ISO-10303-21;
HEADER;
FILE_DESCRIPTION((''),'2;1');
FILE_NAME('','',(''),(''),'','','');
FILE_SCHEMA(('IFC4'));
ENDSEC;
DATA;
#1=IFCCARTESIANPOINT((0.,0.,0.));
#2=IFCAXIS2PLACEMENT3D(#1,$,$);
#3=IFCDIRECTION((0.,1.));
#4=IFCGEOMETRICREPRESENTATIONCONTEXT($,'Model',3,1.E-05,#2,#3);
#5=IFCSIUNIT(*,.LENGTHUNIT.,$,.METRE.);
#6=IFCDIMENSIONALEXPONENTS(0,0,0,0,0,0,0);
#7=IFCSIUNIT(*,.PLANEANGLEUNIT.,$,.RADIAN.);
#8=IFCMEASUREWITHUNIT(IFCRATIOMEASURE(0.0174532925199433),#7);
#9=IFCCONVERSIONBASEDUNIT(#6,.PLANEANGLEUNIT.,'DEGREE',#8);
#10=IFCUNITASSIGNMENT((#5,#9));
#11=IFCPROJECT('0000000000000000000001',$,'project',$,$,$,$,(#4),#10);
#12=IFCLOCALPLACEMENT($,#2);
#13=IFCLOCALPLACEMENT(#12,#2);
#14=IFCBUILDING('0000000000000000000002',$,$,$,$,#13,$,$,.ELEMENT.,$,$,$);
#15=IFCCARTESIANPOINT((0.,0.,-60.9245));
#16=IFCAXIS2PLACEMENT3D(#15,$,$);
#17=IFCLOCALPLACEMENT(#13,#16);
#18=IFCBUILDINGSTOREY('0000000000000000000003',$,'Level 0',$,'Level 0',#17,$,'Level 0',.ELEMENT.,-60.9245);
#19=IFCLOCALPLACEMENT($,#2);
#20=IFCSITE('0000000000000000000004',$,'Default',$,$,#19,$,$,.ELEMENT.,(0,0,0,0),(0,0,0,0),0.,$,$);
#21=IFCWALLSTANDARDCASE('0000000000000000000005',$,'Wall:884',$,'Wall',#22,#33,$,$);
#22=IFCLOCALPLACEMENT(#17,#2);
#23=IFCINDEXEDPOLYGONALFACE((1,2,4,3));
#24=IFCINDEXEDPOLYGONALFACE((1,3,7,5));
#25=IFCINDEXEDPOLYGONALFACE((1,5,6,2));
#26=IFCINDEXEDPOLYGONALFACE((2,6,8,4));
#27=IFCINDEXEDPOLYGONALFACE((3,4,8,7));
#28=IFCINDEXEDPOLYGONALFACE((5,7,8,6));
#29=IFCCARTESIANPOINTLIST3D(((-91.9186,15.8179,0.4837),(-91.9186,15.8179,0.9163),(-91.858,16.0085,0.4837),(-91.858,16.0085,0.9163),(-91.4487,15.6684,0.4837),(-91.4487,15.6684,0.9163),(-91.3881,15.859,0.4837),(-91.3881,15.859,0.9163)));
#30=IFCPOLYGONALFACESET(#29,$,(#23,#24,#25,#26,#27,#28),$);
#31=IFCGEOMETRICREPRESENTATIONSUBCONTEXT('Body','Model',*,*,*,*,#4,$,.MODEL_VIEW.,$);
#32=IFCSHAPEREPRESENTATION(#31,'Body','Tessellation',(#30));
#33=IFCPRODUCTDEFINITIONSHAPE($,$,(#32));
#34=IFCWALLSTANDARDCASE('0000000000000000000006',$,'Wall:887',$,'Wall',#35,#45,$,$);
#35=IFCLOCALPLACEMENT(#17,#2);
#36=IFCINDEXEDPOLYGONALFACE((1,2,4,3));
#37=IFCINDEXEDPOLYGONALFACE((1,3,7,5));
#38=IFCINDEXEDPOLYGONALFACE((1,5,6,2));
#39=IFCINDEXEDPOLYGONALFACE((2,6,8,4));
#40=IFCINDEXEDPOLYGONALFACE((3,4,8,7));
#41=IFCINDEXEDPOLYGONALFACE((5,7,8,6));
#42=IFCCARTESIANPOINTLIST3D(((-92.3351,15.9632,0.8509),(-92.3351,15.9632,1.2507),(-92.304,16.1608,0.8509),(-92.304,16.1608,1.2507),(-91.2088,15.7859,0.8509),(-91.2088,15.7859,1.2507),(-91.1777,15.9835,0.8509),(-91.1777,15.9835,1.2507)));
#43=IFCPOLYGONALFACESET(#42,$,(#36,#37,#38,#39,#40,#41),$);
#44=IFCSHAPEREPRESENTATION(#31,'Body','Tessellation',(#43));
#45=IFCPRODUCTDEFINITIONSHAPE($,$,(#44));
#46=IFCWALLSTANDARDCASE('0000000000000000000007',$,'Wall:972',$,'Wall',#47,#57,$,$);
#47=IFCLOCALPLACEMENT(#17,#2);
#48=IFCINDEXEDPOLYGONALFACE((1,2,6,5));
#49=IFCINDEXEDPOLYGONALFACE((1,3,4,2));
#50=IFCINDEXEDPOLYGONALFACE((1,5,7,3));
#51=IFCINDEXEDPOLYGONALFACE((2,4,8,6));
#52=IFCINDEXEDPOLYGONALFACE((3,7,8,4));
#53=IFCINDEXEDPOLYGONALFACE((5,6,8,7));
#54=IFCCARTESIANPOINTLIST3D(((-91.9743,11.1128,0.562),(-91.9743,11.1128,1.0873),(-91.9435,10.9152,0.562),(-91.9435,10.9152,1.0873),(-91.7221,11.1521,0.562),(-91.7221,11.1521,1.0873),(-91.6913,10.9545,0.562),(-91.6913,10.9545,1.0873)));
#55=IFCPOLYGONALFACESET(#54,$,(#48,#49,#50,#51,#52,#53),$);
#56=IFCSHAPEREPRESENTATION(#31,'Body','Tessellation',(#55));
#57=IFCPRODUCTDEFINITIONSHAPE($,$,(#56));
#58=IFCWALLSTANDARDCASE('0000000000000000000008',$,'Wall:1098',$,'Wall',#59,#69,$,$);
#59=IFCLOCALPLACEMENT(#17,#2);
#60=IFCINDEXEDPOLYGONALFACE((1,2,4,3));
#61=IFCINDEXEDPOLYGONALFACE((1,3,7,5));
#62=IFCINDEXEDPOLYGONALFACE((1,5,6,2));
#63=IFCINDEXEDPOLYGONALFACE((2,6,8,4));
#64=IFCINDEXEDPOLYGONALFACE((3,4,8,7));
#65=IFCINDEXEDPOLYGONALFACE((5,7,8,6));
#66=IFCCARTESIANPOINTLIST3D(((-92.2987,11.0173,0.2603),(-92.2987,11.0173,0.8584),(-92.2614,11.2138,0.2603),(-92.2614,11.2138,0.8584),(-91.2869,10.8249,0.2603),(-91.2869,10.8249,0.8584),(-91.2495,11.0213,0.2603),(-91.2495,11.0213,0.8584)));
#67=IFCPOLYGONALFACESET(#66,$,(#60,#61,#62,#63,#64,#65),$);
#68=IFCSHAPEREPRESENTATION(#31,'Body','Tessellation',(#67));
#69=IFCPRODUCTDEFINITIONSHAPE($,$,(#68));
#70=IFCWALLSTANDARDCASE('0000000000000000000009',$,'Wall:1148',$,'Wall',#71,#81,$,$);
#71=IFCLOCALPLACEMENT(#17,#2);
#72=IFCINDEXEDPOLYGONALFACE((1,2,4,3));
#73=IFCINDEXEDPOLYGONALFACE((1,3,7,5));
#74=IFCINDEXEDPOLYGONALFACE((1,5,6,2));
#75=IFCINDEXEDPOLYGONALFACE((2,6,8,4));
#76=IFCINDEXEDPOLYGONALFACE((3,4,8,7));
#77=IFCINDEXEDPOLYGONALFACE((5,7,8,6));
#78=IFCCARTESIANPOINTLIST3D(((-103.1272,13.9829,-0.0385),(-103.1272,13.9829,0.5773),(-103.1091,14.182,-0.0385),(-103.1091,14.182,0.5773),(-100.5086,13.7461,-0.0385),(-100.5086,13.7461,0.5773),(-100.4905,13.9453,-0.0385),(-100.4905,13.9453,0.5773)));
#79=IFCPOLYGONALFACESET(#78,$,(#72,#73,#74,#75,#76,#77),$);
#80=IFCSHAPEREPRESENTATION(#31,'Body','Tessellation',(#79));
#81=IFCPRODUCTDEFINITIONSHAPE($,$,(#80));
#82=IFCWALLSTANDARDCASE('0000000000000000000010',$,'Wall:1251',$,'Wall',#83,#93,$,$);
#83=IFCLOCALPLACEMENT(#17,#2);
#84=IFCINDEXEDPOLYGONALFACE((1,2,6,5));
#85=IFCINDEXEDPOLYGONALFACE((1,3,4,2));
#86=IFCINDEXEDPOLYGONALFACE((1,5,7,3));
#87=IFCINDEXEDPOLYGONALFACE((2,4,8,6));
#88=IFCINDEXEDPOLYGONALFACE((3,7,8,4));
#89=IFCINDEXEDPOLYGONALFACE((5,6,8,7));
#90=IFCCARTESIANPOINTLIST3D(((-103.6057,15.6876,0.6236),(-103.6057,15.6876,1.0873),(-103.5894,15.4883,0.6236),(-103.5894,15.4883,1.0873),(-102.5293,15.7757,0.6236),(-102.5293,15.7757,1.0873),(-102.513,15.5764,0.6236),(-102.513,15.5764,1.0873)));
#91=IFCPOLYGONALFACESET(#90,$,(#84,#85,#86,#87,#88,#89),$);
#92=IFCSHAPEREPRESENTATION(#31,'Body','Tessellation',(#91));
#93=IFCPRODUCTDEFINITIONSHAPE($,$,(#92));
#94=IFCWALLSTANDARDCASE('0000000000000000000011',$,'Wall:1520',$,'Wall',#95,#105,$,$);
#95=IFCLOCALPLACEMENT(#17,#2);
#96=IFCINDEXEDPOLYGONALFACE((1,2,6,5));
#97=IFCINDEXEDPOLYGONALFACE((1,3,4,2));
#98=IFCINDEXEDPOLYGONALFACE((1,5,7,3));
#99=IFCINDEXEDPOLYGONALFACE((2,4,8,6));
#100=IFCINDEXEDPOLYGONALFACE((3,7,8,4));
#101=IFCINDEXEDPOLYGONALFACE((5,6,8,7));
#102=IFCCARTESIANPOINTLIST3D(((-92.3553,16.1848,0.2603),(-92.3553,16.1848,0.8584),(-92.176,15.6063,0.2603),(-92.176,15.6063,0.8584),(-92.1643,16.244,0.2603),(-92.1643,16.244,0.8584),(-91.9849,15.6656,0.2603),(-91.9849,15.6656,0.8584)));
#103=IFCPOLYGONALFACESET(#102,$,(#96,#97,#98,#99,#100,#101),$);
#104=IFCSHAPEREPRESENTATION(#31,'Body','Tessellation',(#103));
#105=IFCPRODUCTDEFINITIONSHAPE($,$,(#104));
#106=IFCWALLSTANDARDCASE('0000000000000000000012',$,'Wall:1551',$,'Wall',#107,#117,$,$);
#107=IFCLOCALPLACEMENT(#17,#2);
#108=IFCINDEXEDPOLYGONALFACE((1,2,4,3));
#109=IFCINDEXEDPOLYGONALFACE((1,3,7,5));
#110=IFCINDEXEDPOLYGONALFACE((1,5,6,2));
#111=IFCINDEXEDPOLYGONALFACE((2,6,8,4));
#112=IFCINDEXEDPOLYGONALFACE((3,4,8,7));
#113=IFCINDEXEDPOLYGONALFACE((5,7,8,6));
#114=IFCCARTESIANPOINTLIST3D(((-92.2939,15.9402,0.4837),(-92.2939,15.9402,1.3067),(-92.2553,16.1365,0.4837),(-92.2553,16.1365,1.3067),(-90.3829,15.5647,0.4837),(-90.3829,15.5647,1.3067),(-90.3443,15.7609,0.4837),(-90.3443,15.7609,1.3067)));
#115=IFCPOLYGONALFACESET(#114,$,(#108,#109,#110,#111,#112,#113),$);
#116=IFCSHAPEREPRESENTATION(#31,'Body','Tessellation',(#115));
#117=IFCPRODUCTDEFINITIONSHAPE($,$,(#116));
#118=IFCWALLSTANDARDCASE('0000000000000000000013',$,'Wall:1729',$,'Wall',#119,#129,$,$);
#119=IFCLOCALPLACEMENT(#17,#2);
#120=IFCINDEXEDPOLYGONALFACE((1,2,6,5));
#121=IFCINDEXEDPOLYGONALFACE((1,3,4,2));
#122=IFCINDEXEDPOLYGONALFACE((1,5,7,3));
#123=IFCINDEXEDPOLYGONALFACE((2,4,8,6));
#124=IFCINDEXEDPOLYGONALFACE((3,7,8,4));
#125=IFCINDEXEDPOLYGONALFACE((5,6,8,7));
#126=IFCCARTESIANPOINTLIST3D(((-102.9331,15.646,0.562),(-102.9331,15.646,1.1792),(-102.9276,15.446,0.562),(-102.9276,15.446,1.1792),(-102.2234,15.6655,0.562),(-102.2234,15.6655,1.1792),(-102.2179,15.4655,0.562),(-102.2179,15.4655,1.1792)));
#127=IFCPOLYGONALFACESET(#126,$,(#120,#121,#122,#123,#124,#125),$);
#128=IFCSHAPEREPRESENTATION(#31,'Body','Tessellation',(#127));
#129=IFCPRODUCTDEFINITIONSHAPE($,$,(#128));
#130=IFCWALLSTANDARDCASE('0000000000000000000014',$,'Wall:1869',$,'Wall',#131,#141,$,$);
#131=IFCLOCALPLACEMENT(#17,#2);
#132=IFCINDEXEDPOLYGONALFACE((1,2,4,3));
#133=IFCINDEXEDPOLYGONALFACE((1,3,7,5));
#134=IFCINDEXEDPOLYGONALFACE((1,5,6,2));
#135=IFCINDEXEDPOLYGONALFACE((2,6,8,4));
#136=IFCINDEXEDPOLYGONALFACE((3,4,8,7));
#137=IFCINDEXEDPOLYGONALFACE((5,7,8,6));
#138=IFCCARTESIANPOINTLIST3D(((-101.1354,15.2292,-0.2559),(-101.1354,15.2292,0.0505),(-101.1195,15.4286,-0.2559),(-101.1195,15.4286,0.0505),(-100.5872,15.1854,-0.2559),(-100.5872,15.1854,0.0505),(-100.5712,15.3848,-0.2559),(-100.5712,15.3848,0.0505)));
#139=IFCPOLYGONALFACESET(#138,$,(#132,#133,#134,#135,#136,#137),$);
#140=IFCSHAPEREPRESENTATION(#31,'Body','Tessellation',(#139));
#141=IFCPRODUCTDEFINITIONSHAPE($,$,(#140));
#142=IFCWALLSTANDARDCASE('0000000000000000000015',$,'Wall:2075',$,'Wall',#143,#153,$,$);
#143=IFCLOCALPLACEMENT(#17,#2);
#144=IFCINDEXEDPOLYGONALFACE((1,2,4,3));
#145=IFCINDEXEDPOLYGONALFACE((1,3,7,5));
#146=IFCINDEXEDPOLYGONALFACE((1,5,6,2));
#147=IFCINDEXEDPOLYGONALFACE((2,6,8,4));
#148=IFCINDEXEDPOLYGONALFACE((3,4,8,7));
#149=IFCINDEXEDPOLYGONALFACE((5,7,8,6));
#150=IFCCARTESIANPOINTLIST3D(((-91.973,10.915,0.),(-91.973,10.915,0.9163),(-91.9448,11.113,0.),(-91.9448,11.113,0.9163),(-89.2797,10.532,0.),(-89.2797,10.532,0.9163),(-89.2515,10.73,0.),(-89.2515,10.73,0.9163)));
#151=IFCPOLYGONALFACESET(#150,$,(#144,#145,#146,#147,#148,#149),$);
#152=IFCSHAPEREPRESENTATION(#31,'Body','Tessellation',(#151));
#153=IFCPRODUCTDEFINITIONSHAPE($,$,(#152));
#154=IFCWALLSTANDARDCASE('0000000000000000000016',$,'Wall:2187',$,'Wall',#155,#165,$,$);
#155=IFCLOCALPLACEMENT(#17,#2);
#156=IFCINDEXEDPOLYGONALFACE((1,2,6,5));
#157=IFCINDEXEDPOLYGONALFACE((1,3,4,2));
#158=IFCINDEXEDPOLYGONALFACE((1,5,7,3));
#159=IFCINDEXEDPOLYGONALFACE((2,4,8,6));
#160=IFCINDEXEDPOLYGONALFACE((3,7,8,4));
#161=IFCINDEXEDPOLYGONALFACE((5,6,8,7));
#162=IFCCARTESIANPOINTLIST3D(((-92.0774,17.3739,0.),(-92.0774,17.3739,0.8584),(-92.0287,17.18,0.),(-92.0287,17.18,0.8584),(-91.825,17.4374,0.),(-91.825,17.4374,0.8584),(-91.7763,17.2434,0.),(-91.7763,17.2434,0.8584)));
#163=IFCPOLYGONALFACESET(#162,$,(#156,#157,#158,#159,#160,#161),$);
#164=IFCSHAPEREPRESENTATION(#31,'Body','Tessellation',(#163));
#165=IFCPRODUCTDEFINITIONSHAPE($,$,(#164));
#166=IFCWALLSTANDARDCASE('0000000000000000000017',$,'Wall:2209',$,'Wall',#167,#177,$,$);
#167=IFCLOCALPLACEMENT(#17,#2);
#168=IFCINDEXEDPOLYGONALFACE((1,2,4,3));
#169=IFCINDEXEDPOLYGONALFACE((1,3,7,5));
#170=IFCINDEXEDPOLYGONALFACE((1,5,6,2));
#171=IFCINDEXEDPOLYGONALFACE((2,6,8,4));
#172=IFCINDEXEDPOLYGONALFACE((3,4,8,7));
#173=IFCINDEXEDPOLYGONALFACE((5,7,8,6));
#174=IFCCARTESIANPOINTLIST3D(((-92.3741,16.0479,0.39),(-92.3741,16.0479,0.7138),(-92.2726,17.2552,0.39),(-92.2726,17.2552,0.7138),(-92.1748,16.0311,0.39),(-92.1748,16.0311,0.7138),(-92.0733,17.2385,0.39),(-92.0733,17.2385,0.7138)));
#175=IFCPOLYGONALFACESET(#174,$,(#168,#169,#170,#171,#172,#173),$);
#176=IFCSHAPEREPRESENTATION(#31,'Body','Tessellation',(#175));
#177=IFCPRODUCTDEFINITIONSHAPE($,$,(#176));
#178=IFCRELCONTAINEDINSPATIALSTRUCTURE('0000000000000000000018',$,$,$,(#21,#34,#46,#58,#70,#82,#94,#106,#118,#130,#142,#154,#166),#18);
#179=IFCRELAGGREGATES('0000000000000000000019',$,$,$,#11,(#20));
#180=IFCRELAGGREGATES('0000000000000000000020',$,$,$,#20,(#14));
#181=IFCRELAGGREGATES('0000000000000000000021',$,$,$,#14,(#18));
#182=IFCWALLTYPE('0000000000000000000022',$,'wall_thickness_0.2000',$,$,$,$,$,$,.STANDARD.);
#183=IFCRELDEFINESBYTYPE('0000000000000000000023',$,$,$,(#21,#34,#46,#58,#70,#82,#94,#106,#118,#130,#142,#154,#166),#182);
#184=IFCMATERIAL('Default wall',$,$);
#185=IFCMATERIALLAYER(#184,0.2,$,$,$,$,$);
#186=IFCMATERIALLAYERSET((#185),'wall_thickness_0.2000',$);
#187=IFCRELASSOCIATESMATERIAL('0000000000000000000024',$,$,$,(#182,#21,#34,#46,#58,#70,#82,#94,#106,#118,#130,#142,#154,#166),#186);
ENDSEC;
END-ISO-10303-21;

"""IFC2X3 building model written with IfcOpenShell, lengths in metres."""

from ifc_helpers import new_model, entity, si_unit, converted_unit, direction, frame, origin, place, context, subcontext, project, spatial, polyline, outline, extrude, material, layer, layer_set, layer_usage, type_object, element, save


model = new_model("IFC2X3")

# Units and contexts
model_context = context("Model", 3, precision=1e-05, world=origin(), true_north=direction((0.0, 1.0)))
body_context = subcontext(model_context, "Body", "Model", "MODEL_VIEW")
ifc_project = project(units=[si_unit("LENGTHUNIT", "METRE"), converted_unit("PLANEANGLEUNIT", "DEGREE", entity("IfcRatioMeasure", 0.0174532925199433), si_unit("PLANEANGLEUNIT", "RADIAN"), dimensions=[0, 0, 0, 0, 0, 0, 0])], contexts=[model_context])

# Site, building, storey
site_placement = place(None, origin())
site = spatial("IfcSite", under=ifc_project, at=site_placement, Name="Default", CompositionType="ELEMENT", RefLatitude=(0, 0, 0, 0), RefLongitude=(0, 0, 0, 0), RefElevation=0.0)
placement_1 = place(None, origin())
building_placement = place(placement_1, origin())
building = spatial("IfcBuilding", under=site, at=building_placement, CompositionType="ELEMENT")
storey_placement = place(building_placement, frame((0.0, 0.0, -60.9245)))
storey = spatial("IfcBuildingStorey", under=building, at=storey_placement, Name="Level 0", ObjectType="Level 0", LongName="Level 0", CompositionType="ELEMENT", Elevation=-60.9245)

# Walls
ifc_material = material(Name="Default wall")
ifc_layer = layer(ifc_material, 0.2)
ifc_layer_set = layer_set([ifc_layer], Name="wall_thickness_0.2000")
ifc_layer_usage = layer_usage(ifc_layer_set, "AXIS2", "POSITIVE", -0.1)
wall_type = type_object("IfcWallType", Name="wall_thickness_0.2000", PredefinedType="STANDARD", material=ifc_layer_set)
placement_2 = place(building_placement, frame((0.0, 0.0, -60.4408)))
wall_1_placement = place(placement_2, frame((-91.8883, 15.9132, 0.0), z_axis=(0.0, 0.0, 1.0), x_axis=(0.952968, -0.303069, 0.0)))
element("IfcWallStandardCase", 1, at=wall_1_placement, inside=storey, type_object=wall_type, material=ifc_layer_usage, Name="Wall:884", ObjectType="Wall", context=body_context, shape_type="SweptSolid", body=[
    extrude(outline(polyline([(0.4932, -0.1), (0.4932, 0.1), (0.0, 0.1), (0.0, -0.1), (0.4932, -0.1)])), origin(), (0.0, 0.0, 1.0), 0.4326),
])
placement_3 = place(building_placement, frame((0.0, 0.0, -60.0736)))
wall_2_placement = place(placement_3, frame((-92.3195, 16.062, 0.0), z_axis=(0.0, 0.0, 1.0), x_axis=(0.987839, -0.155482, 0.0)))
element("IfcWallStandardCase", 2, at=wall_2_placement, inside=storey, type_object=wall_type, material=ifc_layer_usage, Name="Wall:887", ObjectType="Wall", context=body_context, shape_type="SweptSolid", body=[
    extrude(outline(polyline([(1.1402, -0.1), (1.1402, 0.1), (0.0, 0.1), (0.0, -0.1), (1.1402, -0.1)])), origin(), (0.0, 0.0, 1.0), 0.3998),
])
placement_4 = place(building_placement, frame((0.0, 0.0, -60.3625)))
wall_3_placement = place(placement_4, frame((-91.9589, 11.014, 0.0), z_axis=(0.0, 0.0, 1.0), x_axis=(0.988064, 0.154043, 0.0)))
element("IfcWallStandardCase", 3, at=wall_3_placement, inside=storey, type_object=wall_type, material=ifc_layer_usage, Name="Wall:972", ObjectType="Wall", context=body_context, shape_type="SweptSolid", body=[
    extrude(outline(polyline([(0.2553, -0.1), (0.2553, 0.1), (0.0, 0.1), (0.0, -0.1), (0.2553, -0.1)])), origin(), (0.0, 0.0, 1.0), 0.5254),
])
placement_5 = place(building_placement, frame((0.0, 0.0, -60.6642)))
wall_4_placement = place(placement_5, frame((-92.2801, 11.1156, 0.0), z_axis=(0.0, 0.0, 1.0), x_axis=(0.982384, -0.186874, 0.0)))
element("IfcWallStandardCase", 4, at=wall_4_placement, inside=storey, type_object=wall_type, material=ifc_layer_usage, Name="Wall:1098", ObjectType="Wall", context=body_context, shape_type="SweptSolid", body=[
    extrude(outline(polyline([(1.03, -0.1), (1.03, 0.1), (0.0, 0.1), (0.0, -0.1), (1.03, -0.1)])), origin(), (0.0, 0.0, 1.0), 0.5981),
])
placement_6 = place(building_placement, frame((0.0, 0.0, -60.963)))
wall_5_placement = place(placement_6, frame((-103.1182, 14.0825, 0.0), z_axis=(0.0, 0.0, 1.0), x_axis=(0.995936, -0.09006, 0.0)))
element("IfcWallStandardCase", 5, at=wall_5_placement, inside=storey, type_object=wall_type, material=ifc_layer_usage, Name="Wall:1148", ObjectType="Wall", context=body_context, shape_type="SweptSolid", body=[
    extrude(outline(polyline([(2.6293, -0.1), (2.6293, 0.1), (0.0, 0.1), (0.0, -0.1), (2.6293, -0.1)])), origin(), (0.0, 0.0, 1.0), 0.6158),
])
placement_7 = place(building_placement, frame((0.0, 0.0, -60.3009)))
wall_6_placement = place(placement_7, frame((-103.5975, 15.5879, 0.0), z_axis=(0.0, 0.0, 1.0), x_axis=(0.996665, 0.081608, 0.0)))
element("IfcWallStandardCase", 6, at=wall_6_placement, inside=storey, type_object=wall_type, material=ifc_layer_usage, Name="Wall:1251", ObjectType="Wall", context=body_context, shape_type="SweptSolid", body=[
    extrude(outline(polyline([(1.08, -0.1), (1.08, 0.1), (0.0, 0.1), (0.0, -0.1), (1.08, -0.1)])), origin(), (0.0, 0.0, 1.0), 0.4637),
])
placement_8 = place(building_placement, frame((0.0, 0.0, -60.6642)))
wall_7_placement = place(placement_8, frame((-92.2598, 16.2144, 0.0), z_axis=(0.0, 0.0, 1.0), x_axis=(0.296134, -0.955146, 0.0)))
element("IfcWallStandardCase", 7, at=wall_7_placement, inside=storey, type_object=wall_type, material=ifc_layer_usage, Name="Wall:1520", ObjectType="Wall", context=body_context, shape_type="SweptSolid", body=[
    extrude(outline(polyline([(0.6056, -0.1), (0.6056, 0.1), (0.0, 0.1), (0.0, -0.1), (0.6056, -0.1)])), origin(), (0.0, 0.0, 1.0), 0.5981),
])
placement_9 = place(building_placement, frame((0.0, 0.0, -60.4408)))
wall_8_placement = place(placement_9, frame((-92.2746, 16.0384, 0.0), z_axis=(0.0, 0.0, 1.0), x_axis=(0.981232, -0.192831, 0.0)))
element("IfcWallStandardCase", 8, at=wall_8_placement, inside=storey, type_object=wall_type, material=ifc_layer_usage, Name="Wall:1551", ObjectType="Wall", context=body_context, shape_type="SweptSolid", body=[
    extrude(outline(polyline([(1.9475, -0.1), (1.9475, 0.1), (0.0, 0.1), (0.0, -0.1), (1.9475, -0.1)])), origin(), (0.0, 0.0, 1.0), 0.823),
])
placement_10 = place(building_placement, frame((0.0, 0.0, -60.3625)))
wall_9_placement = place(placement_10, frame((-102.2206, 15.5655, 0.0), z_axis=(0.0, 0.0, 1.0), x_axis=(-0.999623, -0.027458, 0.0)))
element("IfcWallStandardCase", 9, at=wall_9_placement, inside=storey, type_object=wall_type, material=ifc_layer_usage, Name="Wall:1729", ObjectType="Wall", context=body_context, shape_type="SweptSolid", body=[
    extrude(outline(polyline([(0.71, -0.1), (0.71, 0.1), (0.0, 0.1), (0.0, -0.1), (0.71, -0.1)])), origin(), (0.0, 0.0, 1.0), 0.6172),
])
placement_11 = place(building_placement, frame((0.0, 0.0, -61.1804)))
wall_10_placement = place(placement_11, frame((-100.5792, 15.2851, 0.0), z_axis=(0.0, 0.0, 1.0), x_axis=(-0.996819, 0.079698, 0.0)))
element("IfcWallStandardCase", 10, at=wall_10_placement, inside=storey, type_object=wall_type, material=ifc_layer_usage, Name="Wall:1869", ObjectType="Wall", context=body_context, shape_type="SweptSolid", body=[
    extrude(outline(polyline([(0.55, -0.1), (0.55, 0.1), (0.0, 0.1), (0.0, -0.1), (0.55, -0.1)])), origin(), (0.0, 0.0, 1.0), 0.3064),
])
wall_11_placement = place(storey_placement, frame((-91.9589, 11.014, 0.0), z_axis=(0.0, 0.0, 1.0), x_axis=(0.990038, -0.140802, 0.0)))
element("IfcWallStandardCase", 11, at=wall_11_placement, inside=storey, type_object=wall_type, material=ifc_layer_usage, Name="Wall:2075", ObjectType="Wall", context=body_context, shape_type="SweptSolid", body=[
    extrude(outline(polyline([(2.7204, -0.1), (2.7204, 0.1), (0.0, 0.1), (0.0, -0.1), (2.7204, -0.1)])), origin(), (0.0, 0.0, 1.0), 0.9163),
])
wall_12_placement = place(storey_placement, frame((-91.8006, 17.3404, 0.0), z_axis=(0.0, 0.0, 1.0), x_axis=(-0.969859, -0.243667, 0.0)))
element("IfcWallStandardCase", 12, at=wall_12_placement, inside=storey, type_object=wall_type, material=ifc_layer_usage, Name="Wall:2187", ObjectType="Wall", context=body_context, shape_type="SweptSolid", body=[
    extrude(outline(polyline([(0.2603, -0.1), (0.2603, 0.1), (0.0, 0.1), (0.0, -0.1), (0.2603, -0.1)])), origin(), (0.0, 0.0, 1.0), 0.8584),
])
placement_12 = place(building_placement, frame((0.0, 0.0, -60.5345)))
wall_13_placement = place(placement_12, frame((-92.2745, 16.0395, 0.0), z_axis=(0.0, 0.0, 1.0), x_axis=(0.083774, 0.996485, 0.0)))
element("IfcWallStandardCase", 13, at=wall_13_placement, inside=storey, type_object=wall_type, material=ifc_layer_usage, Name="Wall:2209", ObjectType="Wall", context=body_context, shape_type="SweptSolid", body=[
    extrude(outline(polyline([(1.2116, -0.1), (1.2116, 0.1), (0.0, 0.1), (0.0, -0.1), (1.2116, -0.1)])), origin(), (0.0, 0.0, 1.0), 0.3237),
])

save(model, "model.ifc")
